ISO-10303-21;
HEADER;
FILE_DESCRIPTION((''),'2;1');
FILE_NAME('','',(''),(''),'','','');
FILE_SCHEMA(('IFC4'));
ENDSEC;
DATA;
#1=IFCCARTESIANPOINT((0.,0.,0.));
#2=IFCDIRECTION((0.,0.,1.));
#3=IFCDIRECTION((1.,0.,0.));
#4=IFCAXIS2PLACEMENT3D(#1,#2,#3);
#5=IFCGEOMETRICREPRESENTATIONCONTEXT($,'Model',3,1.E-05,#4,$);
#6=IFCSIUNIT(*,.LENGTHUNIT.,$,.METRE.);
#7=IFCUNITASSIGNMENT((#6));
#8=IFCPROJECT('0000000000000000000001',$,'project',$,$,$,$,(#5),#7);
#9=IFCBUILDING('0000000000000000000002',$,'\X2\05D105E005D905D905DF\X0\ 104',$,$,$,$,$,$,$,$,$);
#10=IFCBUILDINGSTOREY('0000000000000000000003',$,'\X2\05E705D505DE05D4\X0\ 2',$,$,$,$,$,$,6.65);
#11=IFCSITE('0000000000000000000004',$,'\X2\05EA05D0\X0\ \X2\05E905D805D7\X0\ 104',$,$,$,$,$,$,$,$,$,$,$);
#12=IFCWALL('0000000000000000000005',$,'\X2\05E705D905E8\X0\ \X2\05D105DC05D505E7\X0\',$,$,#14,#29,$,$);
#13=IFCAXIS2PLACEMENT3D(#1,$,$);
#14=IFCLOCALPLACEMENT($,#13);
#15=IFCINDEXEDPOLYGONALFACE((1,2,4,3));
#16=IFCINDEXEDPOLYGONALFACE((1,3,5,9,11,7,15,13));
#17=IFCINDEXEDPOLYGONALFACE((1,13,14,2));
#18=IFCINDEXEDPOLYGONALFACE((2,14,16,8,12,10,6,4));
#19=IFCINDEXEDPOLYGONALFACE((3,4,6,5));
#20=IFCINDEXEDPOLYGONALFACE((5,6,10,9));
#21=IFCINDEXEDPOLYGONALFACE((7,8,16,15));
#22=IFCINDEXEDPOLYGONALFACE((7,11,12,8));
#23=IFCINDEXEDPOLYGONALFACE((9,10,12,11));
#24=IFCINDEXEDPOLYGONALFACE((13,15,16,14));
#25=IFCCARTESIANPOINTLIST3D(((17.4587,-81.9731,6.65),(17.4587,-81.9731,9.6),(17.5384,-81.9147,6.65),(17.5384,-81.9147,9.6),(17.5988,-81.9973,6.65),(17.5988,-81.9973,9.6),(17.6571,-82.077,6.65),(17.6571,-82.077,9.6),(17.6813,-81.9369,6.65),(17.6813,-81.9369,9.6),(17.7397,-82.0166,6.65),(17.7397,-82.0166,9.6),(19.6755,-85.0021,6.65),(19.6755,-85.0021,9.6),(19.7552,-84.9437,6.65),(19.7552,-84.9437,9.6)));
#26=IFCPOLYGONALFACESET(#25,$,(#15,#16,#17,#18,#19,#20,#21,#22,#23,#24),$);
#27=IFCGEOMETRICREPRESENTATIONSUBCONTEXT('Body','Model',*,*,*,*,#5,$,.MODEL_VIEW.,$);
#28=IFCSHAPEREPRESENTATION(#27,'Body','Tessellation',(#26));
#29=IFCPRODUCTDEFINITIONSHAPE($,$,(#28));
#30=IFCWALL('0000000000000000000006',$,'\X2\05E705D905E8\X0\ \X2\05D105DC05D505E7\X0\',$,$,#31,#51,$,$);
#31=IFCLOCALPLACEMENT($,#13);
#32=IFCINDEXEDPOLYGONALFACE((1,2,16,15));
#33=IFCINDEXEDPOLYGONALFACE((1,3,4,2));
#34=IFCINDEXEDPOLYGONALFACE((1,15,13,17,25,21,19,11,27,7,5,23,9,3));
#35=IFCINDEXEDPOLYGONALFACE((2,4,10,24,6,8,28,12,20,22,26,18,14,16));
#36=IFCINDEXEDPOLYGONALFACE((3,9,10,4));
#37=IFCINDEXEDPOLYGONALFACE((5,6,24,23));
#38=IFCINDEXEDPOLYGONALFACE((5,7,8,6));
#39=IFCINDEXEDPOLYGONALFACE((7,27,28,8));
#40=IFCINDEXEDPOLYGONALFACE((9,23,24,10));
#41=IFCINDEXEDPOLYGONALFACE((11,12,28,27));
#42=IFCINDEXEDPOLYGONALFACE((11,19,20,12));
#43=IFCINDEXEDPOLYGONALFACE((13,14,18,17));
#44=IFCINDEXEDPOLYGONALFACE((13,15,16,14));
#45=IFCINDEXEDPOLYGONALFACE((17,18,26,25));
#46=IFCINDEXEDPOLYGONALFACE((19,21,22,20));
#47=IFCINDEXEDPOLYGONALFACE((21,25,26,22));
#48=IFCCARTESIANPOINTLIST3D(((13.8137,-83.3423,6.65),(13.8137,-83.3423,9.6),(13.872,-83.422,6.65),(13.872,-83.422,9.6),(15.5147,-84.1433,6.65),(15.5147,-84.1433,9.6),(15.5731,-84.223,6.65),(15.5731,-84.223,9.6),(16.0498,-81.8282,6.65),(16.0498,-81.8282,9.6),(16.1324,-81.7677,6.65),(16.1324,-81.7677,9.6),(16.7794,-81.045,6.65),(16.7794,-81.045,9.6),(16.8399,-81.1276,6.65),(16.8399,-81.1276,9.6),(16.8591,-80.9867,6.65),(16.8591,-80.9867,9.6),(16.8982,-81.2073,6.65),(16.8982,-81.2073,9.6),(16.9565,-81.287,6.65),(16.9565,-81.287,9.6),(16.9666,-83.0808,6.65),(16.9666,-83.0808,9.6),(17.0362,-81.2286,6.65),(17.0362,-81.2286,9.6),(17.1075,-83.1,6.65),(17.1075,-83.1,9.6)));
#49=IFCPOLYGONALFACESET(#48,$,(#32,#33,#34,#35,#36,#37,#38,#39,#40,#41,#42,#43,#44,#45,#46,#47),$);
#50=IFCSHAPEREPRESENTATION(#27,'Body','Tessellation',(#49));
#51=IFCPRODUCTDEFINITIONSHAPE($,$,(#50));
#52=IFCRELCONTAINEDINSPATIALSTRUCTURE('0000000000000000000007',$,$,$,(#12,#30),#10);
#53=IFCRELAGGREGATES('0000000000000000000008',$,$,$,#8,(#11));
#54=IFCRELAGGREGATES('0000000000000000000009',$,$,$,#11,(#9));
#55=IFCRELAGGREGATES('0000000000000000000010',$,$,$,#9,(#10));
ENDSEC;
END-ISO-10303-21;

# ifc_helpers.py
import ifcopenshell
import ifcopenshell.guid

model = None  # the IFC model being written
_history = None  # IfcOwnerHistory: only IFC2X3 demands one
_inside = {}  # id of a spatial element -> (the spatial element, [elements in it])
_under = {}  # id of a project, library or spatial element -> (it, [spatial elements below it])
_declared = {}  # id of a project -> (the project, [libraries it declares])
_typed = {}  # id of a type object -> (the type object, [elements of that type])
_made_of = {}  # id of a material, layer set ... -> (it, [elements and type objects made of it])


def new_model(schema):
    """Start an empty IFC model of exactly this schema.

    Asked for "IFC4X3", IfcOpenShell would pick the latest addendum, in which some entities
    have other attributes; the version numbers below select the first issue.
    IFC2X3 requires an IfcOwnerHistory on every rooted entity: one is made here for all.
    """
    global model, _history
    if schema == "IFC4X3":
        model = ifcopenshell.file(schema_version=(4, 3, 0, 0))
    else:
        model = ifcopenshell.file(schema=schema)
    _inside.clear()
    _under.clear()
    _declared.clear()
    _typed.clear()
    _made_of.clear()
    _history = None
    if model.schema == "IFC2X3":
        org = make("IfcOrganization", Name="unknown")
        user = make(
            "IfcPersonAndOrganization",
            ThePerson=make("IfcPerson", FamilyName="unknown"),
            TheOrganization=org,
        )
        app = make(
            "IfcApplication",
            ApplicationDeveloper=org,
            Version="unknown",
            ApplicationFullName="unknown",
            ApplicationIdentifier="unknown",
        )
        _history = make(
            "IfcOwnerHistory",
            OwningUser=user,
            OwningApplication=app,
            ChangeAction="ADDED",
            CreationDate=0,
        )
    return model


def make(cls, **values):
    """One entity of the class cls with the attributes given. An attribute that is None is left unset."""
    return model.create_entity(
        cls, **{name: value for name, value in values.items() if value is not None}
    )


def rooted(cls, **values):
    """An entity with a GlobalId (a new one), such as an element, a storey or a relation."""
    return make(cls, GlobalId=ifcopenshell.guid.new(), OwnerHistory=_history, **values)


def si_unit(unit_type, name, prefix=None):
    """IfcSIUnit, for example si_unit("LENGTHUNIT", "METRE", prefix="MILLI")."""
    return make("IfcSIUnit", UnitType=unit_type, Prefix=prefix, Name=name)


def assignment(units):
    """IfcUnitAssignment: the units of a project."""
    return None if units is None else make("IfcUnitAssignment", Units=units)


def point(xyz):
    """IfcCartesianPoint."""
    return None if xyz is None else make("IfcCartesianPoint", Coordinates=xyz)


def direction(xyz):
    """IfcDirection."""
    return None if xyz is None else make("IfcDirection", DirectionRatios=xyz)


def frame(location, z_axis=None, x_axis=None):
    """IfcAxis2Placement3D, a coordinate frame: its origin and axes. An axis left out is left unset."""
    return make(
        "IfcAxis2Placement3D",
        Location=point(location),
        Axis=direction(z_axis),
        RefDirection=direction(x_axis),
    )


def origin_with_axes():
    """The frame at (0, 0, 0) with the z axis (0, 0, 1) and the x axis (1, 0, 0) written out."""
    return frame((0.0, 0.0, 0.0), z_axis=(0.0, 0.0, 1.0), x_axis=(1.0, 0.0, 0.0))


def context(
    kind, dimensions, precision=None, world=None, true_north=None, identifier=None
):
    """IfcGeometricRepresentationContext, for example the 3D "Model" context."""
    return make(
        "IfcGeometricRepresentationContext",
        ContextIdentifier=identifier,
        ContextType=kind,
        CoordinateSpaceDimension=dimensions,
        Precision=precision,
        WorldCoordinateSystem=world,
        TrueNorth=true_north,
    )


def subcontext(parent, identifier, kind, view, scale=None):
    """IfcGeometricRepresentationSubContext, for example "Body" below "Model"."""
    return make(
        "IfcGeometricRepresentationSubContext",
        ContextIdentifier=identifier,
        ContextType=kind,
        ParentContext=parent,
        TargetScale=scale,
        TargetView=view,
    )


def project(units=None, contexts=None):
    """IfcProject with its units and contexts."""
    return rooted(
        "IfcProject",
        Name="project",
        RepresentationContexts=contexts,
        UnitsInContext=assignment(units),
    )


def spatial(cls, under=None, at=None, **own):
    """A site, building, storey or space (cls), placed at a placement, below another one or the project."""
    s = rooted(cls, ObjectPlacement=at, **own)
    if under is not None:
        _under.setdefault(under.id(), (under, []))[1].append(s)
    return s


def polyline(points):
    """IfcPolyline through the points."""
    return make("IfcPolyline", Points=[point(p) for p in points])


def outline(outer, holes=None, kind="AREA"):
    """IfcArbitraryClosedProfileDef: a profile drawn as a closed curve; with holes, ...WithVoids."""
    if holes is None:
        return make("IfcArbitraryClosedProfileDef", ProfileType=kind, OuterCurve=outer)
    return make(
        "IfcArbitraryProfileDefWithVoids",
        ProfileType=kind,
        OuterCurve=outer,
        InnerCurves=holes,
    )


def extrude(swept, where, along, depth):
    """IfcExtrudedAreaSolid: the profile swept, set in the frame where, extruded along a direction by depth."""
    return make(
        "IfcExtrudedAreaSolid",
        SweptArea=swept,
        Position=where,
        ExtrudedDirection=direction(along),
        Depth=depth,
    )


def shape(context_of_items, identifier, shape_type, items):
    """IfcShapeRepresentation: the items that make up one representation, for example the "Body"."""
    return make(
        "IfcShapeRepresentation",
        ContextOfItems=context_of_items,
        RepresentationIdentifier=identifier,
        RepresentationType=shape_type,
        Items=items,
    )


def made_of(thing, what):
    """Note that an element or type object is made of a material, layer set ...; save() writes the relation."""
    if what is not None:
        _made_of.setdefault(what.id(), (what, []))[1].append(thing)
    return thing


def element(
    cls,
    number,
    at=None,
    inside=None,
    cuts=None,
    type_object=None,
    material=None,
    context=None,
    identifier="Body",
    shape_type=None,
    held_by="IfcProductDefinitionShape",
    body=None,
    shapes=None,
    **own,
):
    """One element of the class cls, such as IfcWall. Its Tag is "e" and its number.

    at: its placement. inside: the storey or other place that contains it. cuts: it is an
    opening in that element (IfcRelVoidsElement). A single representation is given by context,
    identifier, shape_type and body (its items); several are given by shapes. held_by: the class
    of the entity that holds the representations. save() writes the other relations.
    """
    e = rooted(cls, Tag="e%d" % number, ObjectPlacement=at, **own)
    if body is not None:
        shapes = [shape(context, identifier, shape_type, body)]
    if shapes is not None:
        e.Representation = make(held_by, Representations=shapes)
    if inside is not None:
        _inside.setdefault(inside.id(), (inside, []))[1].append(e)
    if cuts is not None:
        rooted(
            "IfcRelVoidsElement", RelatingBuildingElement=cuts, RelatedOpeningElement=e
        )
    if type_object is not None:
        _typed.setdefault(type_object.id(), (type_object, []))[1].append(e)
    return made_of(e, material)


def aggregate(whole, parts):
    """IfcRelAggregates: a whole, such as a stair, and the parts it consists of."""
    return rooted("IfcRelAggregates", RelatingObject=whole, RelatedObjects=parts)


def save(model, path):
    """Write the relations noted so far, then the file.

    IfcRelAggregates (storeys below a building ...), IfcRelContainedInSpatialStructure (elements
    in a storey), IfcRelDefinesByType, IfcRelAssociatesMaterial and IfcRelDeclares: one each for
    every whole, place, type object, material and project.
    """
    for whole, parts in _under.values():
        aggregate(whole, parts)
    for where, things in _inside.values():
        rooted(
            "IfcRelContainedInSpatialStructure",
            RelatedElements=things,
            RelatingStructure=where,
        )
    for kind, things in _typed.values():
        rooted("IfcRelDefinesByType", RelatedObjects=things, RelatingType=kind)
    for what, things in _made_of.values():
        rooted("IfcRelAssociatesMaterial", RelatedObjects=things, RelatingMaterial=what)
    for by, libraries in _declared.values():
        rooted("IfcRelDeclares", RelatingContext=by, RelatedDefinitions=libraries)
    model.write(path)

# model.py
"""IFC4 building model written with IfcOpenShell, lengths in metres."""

from ifc_helpers import new_model, si_unit, frame, origin_with_axes, context, subcontext, project, spatial, polyline, outline, extrude, element, save


model = new_model("IFC4")

# Units and contexts
model_context = context("Model", 3, precision=1e-05, world=origin_with_axes())
body_context = subcontext(model_context, "Body", "Model", "MODEL_VIEW")
ifc_project = project(units=[si_unit("LENGTHUNIT", "METRE")], contexts=[model_context])

# Site, building, storey
site = spatial("IfcSite", under=ifc_project, Name="תא שטח 104")
building = spatial("IfcBuilding", under=site, Name="בניין 104")
storey = spatial("IfcBuildingStorey", under=building, Name="קומה 2", Elevation=6.65)

# Walls
element("IfcWall", 1, inside=storey, Name="קיר בלוק", context=body_context, shape_type="SweptSolid", body=[
    extrude(outline(polyline([(17.5384, -81.9147), (17.4587, -81.9731), (19.6755, -85.0021), (19.7552, -84.9437), (17.6571, -82.077), (17.7397, -82.0166), (17.6813, -81.9369), (17.5988, -81.9973), (17.5384, -81.9147)])), frame((0.0, 0.0, 6.65)), (0.0, 0.0, 1.0), 2.95),
])
element("IfcWall", 2, inside=storey, Name="קיר בלוק", context=body_context, shape_type="SweptSolid", body=[
    extrude(outline(polyline([(16.8399, -81.1276), (13.8137, -83.3423), (13.872, -83.422), (16.0498, -81.8282), (16.9666, -83.0808), (15.5147, -84.1433), (15.5731, -84.223), (17.1075, -83.1), (16.1324, -81.7677), (16.8982, -81.2073), (16.9565, -81.287), (17.0362, -81.2286), (16.8591, -80.9867), (16.7794, -81.045), (16.8399, -81.1276)])), frame((0.0, 0.0, 6.65)), (0.0, 0.0, 1.0), 2.95),
])

save(model, "model.ifc")
